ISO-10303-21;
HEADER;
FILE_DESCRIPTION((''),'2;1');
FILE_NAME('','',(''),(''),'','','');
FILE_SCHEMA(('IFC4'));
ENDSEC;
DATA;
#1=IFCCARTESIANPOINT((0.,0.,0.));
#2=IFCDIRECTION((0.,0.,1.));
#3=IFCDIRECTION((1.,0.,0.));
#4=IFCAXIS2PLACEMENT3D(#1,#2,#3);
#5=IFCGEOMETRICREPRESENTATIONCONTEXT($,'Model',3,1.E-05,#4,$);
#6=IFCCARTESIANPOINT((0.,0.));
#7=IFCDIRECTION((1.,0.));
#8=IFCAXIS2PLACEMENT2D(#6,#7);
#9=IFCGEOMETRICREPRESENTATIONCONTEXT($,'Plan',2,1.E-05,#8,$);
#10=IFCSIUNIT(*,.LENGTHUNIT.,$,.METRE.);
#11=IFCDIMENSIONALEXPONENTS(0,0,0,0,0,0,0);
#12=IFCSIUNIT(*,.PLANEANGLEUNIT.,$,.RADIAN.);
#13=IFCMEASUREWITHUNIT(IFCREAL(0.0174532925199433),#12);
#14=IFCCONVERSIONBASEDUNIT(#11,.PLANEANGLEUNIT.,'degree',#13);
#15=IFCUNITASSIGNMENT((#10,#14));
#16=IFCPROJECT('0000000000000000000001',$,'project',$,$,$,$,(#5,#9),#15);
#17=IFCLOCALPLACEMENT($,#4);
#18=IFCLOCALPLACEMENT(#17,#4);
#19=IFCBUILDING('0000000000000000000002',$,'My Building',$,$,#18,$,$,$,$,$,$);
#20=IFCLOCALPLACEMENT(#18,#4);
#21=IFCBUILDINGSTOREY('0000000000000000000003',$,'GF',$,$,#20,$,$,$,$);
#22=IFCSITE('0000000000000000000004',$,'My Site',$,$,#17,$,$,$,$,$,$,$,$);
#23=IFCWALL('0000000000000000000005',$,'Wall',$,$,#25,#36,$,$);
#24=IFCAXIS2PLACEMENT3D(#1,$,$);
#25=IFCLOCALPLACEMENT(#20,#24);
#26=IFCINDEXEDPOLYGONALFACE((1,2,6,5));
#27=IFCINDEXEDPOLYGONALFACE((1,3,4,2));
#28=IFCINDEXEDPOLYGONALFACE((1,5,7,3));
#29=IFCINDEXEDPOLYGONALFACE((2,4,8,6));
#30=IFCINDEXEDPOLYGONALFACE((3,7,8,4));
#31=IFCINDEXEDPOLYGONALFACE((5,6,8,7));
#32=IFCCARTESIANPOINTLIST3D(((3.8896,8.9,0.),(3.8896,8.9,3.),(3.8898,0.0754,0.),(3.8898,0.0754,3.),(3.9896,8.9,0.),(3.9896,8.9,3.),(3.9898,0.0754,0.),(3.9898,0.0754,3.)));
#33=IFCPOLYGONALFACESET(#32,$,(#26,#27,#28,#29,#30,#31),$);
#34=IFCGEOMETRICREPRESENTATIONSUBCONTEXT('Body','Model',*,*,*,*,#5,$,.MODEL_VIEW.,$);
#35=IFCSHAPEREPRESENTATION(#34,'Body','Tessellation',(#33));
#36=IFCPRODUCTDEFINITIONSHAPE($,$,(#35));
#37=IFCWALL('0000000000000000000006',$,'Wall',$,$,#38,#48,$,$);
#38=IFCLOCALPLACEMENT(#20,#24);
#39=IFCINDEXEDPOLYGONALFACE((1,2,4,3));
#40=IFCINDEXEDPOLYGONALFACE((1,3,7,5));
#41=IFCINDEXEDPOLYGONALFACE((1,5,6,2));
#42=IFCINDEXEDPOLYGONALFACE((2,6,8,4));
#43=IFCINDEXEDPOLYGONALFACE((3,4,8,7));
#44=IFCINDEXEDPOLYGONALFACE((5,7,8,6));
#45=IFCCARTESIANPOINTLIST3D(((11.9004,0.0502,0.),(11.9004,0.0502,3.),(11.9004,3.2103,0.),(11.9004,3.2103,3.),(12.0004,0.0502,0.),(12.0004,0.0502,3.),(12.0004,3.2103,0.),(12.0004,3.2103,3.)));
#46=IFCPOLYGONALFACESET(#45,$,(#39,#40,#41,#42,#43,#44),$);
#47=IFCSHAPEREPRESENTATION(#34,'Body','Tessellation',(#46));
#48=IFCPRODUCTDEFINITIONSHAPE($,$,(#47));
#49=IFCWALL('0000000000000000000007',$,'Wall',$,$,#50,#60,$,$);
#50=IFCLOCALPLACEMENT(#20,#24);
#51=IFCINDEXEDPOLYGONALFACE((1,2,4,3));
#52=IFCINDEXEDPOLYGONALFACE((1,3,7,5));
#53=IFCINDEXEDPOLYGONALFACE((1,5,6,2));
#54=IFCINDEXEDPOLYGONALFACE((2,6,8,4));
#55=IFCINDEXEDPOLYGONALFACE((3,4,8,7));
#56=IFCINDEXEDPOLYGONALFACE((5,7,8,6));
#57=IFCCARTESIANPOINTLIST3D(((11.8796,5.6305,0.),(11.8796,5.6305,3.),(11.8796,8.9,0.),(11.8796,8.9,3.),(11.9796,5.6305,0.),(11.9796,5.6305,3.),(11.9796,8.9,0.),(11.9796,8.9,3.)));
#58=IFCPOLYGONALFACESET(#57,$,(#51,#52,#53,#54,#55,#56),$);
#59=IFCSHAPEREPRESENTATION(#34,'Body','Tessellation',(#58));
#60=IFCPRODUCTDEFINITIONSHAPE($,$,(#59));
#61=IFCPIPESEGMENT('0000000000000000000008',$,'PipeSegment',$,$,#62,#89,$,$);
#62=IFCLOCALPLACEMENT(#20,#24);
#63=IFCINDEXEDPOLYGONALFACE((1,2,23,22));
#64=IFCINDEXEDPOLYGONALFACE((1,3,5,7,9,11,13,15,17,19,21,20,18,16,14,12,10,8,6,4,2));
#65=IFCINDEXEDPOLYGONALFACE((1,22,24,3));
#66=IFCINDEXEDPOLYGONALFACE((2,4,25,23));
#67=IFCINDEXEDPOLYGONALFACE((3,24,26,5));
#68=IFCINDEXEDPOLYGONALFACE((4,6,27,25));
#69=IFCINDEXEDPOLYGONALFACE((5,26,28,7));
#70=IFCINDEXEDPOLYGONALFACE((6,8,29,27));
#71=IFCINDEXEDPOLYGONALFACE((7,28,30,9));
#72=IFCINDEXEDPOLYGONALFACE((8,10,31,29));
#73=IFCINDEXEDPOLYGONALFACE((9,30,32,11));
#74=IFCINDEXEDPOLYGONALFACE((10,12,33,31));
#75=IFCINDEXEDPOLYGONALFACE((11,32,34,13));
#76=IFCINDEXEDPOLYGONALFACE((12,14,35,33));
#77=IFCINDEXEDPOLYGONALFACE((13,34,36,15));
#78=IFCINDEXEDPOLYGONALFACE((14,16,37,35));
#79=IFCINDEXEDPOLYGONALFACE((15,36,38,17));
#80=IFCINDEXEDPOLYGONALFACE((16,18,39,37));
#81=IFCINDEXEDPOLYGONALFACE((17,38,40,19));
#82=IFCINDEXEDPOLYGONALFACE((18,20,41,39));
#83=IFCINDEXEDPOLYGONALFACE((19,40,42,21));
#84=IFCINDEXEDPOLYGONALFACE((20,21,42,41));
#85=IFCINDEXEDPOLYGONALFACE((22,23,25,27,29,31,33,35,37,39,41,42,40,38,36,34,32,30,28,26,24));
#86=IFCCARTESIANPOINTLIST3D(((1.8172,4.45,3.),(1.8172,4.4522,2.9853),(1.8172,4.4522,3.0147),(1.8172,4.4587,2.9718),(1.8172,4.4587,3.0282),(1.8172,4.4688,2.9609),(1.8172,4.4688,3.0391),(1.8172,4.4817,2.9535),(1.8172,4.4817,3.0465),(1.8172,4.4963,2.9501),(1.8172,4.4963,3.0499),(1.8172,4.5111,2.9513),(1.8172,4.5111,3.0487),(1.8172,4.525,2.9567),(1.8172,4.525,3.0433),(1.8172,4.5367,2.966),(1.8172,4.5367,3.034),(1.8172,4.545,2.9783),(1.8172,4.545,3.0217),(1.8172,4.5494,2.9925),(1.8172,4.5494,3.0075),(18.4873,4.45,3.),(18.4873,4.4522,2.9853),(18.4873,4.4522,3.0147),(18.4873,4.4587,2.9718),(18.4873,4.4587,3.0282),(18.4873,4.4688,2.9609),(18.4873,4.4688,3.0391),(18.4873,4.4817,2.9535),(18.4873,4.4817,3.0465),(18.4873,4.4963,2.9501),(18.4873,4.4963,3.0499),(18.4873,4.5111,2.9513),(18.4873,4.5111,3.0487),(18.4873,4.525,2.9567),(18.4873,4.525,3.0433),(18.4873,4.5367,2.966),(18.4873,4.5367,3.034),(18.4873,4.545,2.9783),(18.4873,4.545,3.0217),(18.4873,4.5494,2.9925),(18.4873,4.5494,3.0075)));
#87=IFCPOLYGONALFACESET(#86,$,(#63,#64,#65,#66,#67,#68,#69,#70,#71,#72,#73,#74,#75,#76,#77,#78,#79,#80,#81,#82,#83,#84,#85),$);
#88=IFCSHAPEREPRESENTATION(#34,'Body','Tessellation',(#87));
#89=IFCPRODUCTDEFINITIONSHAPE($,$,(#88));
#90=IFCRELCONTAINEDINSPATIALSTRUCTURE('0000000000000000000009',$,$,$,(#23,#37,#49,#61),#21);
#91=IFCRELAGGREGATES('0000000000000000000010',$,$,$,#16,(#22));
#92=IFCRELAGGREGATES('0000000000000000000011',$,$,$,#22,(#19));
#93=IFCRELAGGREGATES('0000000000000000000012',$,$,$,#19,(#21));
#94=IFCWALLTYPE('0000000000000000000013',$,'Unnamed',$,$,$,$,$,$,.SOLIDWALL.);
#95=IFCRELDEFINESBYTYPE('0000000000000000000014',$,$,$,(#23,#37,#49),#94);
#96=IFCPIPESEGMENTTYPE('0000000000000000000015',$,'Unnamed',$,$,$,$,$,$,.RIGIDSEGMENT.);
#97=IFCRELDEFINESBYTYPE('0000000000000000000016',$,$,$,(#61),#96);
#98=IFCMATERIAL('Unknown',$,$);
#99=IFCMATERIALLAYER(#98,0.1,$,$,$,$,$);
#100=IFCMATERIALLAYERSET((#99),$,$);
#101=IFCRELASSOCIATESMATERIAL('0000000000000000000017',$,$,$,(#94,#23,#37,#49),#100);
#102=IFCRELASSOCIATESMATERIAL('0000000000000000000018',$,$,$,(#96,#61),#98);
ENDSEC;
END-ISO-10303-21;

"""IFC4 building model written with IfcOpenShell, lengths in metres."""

from ifc_helpers import new_model, entity, si_unit, converted_unit, frame, origin_with_axes, origin_2d_with_axis, place, context, subcontext, project, spatial, line, indexed_curve, circle, outline, extrude, material, layer, layer_set, layer_usage, material_profile, profile_set, profile_usage, type_object, element, save


model = new_model("IFC4")

# Units and contexts
model_context = context("Model", 3, precision=1e-05, world=origin_with_axes())
plan_context = context("Plan", 2, precision=1e-05, world=origin_2d_with_axis())
body_context_1 = subcontext(model_context, "Body", "Model", "MODEL_VIEW")
ifc_project = project(units=[si_unit("LENGTHUNIT", "METRE"), converted_unit("PLANEANGLEUNIT", "degree", entity("IfcReal", 0.0174532925199433), si_unit("PLANEANGLEUNIT", "RADIAN"), dimensions=[0, 0, 0, 0, 0, 0, 0])], contexts=[model_context, plan_context])

# Site, building, storey
site_placement = place(None, origin_with_axes())
site = spatial("IfcSite", under=ifc_project, at=site_placement, Name="My Site")
building_placement = place(site_placement, origin_with_axes())
building = spatial("IfcBuilding", under=site, at=building_placement, Name="My Building")
storey_placement = place(building_placement, origin_with_axes())
storey = spatial("IfcBuildingStorey", under=building, at=storey_placement, Name="GF")

# Shared definitions
ifc_material = material(Name="Unknown")
ifc_layer = layer(ifc_material, 0.1)
ifc_layer_set = layer_set([ifc_layer])
wall_type = type_object("IfcWallType", Name="Unnamed", PredefinedType="SOLIDWALL", material=ifc_layer_set)

# Walls
ifc_layer_usage_1 = layer_usage(ifc_layer_set, "AXIS2", "POSITIVE", 0.0)
wall_1_placement = place(storey_placement, frame((3.9898, 0.0754, 0.0), z_axis=(0.0, 0.0, 1.0), x_axis=(-0.000021, 1.0, 0.0)))
element("IfcWall", 1, at=wall_1_placement, inside=storey, type_object=wall_type, material=ifc_layer_usage_1, Name="Wall", context=body_context_1, shape_type="SweptSolid", body=[
    extrude(outline(indexed_curve([(0.0, 0.0), (0.0, 0.1), (8.8246, 0.1), (8.8246, 0.0)], segments=[line(1, 2, 3, 4, 1)])), origin_with_axes(), (0.0, 0.0, 1.0), 3.0),
])
ifc_layer_usage_2 = layer_usage(ifc_layer_set, "AXIS2", "POSITIVE", 0.0)
wall_2_placement = place(storey_placement, frame((12.0004, 0.0502, 0.0), z_axis=(0.0, 0.0, 1.0), x_axis=(0.000013, 1.0, 0.0)))
element("IfcWall", 2, at=wall_2_placement, inside=storey, type_object=wall_type, material=ifc_layer_usage_2, Name="Wall", context=body_context_1, shape_type="SweptSolid", body=[
    extrude(outline(indexed_curve([(0.0, 0.0), (0.0, 0.1), (3.1602, 0.1), (3.1602, 0.0)], segments=[line(1, 2, 3, 4, 1)])), origin_with_axes(), (0.0, 0.0, 1.0), 3.0),
])
ifc_layer_usage_3 = layer_usage(ifc_layer_set, "AXIS2", "POSITIVE", 0.0)
wall_3_placement = place(storey_placement, frame((11.9796, 5.6305, 0.0), z_axis=(0.0, 0.0, 1.0), x_axis=(0.0, 1.0, 0.0)))
element("IfcWall", 3, at=wall_3_placement, inside=storey, type_object=wall_type, material=ifc_layer_usage_3, Name="Wall", context=body_context_1, shape_type="SweptSolid", body=[
    extrude(outline(indexed_curve([(0.0, 0.0), (0.0, 0.1), (3.2695, 0.1), (3.2695, 0.0)], segments=[line(1, 2, 3, 4, 1)])), origin_with_axes(), (0.0, 0.0, 1.0), 3.0),
])

# Pipe segment
ifc_material_profile = material_profile(ifc_material, circle(Radius=0.05))
ifc_profile_set = profile_set([ifc_material_profile])
ifc_profile_usage = profile_usage(ifc_profile_set, cardinal=5)
pipe_segment_type = type_object("IfcPipeSegmentType", Name="Unnamed", PredefinedType="RIGIDSEGMENT", material=ifc_profile_set)
pipe_segment_placement = place(storey_placement, frame((18.4873, 4.5, 3.0), z_axis=(-1.0, 0.0, 0.0), x_axis=(0.0, -1.0, 0.0)))
element("IfcPipeSegment", 4, at=pipe_segment_placement, inside=storey, type_object=pipe_segment_type, material=ifc_profile_usage, Name="PipeSegment", context=body_context_1, shape_type="SweptSolid", body=[
    extrude(circle(Radius=0.05), origin_with_axes(), (0.0, 0.0, 1.0), 16.6701),
])

save(model, "model.ifc")
